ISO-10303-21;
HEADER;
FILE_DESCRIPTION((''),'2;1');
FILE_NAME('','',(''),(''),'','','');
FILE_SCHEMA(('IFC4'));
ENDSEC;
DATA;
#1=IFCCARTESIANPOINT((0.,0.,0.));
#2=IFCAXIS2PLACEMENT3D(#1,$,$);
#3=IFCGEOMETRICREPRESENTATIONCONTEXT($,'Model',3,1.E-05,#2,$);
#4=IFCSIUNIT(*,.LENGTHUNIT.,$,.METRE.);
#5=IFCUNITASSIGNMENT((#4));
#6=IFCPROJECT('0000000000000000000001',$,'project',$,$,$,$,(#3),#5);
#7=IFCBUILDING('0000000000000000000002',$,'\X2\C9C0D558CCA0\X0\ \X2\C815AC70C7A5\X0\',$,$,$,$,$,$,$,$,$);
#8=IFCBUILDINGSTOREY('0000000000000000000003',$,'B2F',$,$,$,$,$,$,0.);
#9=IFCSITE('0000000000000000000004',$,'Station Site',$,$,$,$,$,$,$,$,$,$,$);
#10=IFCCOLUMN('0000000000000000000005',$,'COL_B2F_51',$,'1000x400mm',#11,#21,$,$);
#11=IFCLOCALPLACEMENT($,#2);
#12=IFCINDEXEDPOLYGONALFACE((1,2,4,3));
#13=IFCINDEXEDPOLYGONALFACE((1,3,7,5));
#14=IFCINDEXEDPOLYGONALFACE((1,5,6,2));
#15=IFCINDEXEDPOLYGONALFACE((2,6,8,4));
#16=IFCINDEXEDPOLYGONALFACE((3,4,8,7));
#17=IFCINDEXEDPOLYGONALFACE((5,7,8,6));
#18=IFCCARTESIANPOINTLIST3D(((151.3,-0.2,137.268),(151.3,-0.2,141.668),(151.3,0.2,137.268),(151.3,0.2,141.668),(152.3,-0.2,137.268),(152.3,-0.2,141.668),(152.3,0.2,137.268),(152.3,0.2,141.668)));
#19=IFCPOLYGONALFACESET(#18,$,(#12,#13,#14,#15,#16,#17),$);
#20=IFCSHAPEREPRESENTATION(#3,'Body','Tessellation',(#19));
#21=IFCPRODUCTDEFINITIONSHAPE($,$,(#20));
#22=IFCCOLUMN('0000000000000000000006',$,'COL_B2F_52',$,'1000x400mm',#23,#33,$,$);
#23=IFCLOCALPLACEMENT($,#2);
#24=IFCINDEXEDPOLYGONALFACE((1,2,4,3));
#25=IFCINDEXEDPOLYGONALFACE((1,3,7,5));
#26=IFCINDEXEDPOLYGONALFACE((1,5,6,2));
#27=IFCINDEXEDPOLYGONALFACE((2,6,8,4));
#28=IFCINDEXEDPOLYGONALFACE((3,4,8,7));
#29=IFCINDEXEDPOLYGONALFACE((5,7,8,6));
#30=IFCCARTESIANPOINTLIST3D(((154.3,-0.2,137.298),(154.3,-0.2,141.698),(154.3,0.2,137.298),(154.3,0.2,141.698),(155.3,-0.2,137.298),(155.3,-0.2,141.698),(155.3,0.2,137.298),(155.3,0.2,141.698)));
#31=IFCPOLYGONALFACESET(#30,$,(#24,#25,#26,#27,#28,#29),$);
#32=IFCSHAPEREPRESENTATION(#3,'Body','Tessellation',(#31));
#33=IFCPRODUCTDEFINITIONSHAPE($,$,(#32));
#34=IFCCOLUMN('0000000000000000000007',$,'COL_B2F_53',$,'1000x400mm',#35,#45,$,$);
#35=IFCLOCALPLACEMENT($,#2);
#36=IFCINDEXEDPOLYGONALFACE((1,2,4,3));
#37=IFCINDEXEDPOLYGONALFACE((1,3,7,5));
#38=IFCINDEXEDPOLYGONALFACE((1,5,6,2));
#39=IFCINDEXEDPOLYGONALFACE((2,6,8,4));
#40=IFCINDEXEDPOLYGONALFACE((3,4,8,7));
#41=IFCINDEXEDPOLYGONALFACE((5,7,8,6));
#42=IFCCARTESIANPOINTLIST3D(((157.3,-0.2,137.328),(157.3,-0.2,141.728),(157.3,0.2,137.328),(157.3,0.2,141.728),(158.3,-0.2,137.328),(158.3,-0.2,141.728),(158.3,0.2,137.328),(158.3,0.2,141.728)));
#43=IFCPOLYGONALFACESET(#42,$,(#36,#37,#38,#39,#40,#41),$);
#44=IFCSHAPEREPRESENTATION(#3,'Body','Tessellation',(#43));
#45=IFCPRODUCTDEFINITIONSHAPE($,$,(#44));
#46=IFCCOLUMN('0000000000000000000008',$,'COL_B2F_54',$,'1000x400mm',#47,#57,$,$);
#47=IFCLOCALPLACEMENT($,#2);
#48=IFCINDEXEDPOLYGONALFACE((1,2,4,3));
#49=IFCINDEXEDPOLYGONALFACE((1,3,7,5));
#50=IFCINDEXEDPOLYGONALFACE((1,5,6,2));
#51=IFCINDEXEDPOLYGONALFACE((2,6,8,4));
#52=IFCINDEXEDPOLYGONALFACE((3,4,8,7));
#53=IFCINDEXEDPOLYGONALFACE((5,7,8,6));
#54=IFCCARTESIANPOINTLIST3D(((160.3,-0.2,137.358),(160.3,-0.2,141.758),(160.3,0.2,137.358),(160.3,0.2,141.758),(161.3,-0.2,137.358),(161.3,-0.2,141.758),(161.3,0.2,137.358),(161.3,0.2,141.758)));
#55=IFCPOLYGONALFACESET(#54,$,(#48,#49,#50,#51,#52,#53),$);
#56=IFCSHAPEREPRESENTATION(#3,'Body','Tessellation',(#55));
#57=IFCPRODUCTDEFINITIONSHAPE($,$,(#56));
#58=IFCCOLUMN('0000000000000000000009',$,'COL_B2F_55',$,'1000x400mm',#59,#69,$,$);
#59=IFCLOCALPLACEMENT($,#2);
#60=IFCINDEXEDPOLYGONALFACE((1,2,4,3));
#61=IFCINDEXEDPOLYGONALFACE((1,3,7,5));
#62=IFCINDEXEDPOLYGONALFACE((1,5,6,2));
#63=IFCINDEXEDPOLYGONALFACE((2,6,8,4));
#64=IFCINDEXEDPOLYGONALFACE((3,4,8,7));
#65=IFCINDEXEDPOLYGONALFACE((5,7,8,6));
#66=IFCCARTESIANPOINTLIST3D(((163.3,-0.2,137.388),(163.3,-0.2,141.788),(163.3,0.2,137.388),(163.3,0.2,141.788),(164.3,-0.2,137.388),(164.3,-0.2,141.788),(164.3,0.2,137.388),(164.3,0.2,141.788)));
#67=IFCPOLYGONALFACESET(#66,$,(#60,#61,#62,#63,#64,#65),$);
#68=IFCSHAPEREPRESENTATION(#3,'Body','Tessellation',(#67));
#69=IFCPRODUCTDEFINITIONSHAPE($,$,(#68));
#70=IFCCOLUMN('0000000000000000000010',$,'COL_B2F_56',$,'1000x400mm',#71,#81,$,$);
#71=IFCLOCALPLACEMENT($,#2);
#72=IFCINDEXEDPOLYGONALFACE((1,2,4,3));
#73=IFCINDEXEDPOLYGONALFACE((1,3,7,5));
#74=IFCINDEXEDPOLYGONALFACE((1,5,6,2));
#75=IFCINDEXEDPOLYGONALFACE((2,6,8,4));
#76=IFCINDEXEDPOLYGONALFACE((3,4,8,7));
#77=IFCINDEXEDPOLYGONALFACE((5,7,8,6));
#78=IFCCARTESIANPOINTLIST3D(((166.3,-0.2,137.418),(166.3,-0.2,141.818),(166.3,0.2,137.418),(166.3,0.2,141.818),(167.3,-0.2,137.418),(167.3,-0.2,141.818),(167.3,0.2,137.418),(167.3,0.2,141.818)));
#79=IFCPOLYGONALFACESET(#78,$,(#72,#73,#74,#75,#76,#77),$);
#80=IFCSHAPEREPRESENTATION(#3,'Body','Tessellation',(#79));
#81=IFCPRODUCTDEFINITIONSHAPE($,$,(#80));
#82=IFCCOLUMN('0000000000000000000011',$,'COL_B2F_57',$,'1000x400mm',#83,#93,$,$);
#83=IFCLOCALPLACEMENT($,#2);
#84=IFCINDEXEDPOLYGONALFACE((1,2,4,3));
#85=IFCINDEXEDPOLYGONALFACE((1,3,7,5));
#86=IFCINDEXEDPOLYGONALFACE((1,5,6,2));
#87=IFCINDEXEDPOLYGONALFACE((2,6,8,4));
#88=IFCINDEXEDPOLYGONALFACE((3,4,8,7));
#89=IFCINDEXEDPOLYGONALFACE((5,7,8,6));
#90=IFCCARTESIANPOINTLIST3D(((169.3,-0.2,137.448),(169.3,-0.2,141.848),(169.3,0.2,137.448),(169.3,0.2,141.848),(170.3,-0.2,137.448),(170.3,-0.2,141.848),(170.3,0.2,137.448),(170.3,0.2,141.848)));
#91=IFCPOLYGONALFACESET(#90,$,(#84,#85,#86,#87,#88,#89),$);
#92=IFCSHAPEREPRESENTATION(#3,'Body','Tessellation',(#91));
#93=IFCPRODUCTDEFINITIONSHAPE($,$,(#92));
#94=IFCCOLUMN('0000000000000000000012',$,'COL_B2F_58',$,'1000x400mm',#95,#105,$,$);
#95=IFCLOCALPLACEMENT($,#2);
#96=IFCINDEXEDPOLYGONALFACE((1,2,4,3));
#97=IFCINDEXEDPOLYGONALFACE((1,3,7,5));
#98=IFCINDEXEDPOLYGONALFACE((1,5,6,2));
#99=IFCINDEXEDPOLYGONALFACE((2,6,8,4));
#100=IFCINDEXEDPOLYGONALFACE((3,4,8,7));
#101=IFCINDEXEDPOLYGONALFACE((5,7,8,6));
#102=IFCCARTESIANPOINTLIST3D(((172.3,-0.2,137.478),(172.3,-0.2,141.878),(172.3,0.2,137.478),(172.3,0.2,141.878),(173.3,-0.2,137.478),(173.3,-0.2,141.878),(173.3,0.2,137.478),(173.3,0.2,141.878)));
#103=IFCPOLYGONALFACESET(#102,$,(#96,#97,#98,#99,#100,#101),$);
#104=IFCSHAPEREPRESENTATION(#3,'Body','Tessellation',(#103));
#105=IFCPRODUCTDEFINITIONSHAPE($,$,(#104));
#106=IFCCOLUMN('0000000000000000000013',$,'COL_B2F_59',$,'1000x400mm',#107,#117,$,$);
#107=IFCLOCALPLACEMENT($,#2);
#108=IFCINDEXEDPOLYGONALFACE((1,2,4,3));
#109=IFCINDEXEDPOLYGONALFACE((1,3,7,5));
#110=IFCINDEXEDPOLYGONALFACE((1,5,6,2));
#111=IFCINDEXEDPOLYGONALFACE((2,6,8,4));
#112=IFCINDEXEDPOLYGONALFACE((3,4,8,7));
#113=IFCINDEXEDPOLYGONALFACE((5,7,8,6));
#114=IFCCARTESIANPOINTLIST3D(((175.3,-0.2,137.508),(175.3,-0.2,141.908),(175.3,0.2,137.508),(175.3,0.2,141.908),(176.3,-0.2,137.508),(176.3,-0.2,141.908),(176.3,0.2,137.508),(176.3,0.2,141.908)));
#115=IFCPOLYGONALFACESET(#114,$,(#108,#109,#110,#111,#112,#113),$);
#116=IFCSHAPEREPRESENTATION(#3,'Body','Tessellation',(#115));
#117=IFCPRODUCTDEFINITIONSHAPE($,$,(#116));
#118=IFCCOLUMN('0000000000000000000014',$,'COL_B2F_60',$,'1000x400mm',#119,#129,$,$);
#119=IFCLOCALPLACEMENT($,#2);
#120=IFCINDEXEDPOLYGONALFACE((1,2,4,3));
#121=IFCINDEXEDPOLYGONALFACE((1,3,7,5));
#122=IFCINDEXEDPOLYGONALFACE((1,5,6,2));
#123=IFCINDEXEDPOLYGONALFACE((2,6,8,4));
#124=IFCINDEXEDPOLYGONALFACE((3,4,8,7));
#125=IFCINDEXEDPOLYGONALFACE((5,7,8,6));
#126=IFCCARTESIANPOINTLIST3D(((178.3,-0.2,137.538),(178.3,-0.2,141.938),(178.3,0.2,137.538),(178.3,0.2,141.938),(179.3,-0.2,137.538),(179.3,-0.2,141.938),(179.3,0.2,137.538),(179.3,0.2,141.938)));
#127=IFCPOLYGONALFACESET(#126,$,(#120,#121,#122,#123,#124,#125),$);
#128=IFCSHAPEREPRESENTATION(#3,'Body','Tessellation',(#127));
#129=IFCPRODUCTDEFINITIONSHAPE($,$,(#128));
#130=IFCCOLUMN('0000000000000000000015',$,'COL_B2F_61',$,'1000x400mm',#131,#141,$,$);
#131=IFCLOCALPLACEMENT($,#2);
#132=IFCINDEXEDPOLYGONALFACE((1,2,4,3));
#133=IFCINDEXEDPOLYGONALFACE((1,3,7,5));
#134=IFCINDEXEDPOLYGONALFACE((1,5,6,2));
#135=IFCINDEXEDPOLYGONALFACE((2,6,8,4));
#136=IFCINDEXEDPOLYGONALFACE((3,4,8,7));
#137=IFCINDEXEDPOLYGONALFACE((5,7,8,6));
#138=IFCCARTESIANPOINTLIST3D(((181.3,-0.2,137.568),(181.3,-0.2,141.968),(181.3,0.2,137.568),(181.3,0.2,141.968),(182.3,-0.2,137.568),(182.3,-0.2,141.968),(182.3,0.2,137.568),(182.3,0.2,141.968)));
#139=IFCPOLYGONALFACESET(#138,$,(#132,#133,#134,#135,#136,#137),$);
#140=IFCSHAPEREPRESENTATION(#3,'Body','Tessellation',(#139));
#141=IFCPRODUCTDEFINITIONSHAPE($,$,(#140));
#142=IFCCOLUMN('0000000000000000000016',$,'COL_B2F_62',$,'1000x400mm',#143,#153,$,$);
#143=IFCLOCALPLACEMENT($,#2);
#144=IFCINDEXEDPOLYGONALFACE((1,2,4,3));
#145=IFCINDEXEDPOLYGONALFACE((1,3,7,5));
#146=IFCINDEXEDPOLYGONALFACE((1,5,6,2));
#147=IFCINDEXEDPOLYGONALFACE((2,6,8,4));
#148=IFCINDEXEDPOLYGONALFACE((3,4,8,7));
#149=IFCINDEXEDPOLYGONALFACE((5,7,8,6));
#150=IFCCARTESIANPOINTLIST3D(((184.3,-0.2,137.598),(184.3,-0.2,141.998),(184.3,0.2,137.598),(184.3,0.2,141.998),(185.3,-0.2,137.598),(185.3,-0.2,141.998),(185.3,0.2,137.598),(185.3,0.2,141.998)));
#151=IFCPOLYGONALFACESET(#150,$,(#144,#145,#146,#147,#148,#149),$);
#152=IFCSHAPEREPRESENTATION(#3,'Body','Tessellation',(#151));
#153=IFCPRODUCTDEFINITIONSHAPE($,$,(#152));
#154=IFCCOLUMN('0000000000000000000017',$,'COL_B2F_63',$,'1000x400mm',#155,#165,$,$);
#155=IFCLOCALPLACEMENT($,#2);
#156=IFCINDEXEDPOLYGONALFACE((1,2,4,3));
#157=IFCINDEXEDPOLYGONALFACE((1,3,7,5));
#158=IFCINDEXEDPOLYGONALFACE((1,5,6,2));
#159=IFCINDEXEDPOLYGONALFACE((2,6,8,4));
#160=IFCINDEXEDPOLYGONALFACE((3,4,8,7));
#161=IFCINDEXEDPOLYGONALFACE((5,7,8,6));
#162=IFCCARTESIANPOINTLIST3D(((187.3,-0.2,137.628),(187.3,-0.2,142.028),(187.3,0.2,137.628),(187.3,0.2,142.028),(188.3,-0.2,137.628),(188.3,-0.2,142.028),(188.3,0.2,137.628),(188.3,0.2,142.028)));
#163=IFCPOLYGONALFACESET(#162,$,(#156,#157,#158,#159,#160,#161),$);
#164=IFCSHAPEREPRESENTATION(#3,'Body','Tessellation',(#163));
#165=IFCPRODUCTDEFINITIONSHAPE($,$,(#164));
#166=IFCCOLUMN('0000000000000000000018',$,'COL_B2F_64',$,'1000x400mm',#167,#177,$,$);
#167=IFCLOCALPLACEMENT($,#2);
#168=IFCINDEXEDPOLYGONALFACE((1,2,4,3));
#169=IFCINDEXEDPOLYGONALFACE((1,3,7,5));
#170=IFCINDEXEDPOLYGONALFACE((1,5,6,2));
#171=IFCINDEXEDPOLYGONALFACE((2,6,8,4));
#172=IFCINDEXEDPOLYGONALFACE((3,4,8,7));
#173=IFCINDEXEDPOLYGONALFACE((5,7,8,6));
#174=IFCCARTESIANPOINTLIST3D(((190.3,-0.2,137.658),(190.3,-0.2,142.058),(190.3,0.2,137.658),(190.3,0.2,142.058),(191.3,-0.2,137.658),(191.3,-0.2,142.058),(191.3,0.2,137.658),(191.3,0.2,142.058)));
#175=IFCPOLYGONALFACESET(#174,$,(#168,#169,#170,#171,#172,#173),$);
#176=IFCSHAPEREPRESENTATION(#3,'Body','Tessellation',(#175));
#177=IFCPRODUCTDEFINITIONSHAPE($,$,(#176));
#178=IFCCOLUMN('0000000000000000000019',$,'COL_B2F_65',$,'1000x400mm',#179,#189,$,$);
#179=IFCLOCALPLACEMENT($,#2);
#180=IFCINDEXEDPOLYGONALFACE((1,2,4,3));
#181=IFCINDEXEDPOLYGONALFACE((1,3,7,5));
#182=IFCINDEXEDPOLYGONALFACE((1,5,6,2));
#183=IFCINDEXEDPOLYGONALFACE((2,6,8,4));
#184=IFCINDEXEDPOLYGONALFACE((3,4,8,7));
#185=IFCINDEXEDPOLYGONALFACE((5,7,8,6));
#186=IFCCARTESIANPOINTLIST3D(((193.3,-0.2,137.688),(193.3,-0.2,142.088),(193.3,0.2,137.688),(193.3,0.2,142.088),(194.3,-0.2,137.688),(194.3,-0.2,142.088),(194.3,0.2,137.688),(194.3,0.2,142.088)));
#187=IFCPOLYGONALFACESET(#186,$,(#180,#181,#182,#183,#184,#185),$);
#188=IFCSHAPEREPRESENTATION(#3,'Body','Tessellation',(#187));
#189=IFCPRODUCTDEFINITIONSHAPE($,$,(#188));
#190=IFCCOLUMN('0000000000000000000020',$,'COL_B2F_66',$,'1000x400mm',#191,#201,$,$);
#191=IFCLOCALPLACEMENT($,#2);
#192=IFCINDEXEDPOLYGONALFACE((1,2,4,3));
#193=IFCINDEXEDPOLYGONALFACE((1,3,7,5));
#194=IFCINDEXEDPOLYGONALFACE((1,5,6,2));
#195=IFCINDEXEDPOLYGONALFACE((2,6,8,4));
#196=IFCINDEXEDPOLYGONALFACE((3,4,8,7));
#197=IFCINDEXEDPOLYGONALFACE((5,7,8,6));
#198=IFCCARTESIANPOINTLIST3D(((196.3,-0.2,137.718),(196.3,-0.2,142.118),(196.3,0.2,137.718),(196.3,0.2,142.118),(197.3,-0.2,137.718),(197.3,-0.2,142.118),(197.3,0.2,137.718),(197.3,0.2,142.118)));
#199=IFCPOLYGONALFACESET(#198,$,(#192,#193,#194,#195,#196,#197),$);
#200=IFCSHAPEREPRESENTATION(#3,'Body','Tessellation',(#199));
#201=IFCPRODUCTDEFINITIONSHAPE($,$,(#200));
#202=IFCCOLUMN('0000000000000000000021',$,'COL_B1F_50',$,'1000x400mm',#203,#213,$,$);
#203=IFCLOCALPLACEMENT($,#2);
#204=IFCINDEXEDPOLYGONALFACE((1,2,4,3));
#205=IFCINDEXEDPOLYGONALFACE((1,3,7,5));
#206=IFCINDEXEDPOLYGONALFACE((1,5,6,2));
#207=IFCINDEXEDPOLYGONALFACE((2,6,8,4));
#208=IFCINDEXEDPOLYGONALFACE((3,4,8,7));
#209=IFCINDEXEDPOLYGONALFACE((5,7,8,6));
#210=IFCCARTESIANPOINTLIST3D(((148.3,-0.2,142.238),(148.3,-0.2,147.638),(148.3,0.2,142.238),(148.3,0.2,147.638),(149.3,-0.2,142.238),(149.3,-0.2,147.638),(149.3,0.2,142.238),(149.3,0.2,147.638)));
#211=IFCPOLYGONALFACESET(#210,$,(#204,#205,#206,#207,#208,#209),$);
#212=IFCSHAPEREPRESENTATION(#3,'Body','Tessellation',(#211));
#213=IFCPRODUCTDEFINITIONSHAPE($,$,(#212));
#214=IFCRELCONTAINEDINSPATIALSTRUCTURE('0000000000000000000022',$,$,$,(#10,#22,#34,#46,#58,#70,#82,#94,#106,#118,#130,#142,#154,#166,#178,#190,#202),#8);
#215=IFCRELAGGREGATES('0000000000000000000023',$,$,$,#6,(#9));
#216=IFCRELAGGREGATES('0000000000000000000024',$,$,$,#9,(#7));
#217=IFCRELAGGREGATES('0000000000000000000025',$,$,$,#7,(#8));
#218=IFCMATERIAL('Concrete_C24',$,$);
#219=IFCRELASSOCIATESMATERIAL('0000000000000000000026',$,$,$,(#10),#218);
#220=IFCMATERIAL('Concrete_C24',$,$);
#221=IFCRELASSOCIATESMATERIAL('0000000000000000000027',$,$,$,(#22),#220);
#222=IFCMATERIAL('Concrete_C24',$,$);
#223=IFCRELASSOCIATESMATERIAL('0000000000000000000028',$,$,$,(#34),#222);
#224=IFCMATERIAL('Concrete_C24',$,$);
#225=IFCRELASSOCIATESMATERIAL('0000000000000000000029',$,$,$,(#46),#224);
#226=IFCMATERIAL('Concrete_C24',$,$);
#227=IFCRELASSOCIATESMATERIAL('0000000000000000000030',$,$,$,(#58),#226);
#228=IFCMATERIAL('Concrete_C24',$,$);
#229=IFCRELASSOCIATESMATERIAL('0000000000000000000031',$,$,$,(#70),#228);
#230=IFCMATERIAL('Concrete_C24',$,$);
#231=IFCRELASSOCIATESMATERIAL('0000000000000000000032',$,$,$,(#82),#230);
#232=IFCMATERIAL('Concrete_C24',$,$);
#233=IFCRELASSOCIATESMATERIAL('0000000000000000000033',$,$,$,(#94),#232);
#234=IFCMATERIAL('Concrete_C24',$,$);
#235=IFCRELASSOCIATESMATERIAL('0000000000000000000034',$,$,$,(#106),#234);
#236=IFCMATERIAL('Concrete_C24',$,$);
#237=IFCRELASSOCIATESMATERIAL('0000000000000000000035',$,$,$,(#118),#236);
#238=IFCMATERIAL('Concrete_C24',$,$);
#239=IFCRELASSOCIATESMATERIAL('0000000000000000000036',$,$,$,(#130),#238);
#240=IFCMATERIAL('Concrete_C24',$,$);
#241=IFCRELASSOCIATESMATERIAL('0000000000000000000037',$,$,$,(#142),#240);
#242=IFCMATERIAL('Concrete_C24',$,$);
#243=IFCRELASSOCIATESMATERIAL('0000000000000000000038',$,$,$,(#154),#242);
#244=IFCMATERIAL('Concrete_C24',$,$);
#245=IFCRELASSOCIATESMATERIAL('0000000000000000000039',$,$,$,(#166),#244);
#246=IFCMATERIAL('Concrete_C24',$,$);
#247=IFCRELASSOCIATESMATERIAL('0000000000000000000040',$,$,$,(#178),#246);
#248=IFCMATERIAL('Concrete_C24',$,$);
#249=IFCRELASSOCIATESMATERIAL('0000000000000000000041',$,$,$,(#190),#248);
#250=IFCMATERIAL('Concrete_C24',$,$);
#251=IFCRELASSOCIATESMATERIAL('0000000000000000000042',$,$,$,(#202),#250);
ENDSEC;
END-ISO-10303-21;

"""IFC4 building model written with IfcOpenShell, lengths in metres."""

from ifc_helpers import new_model, si_unit, frame, origin, place, context, project, spatial, rectangle, extrude, material, element, save


model = new_model("IFC4")

# Units and contexts
model_context = context("Model", 3, precision=1e-05, world=origin())
ifc_project = project(units=[si_unit("LENGTHUNIT", "METRE")], contexts=[model_context])

# Site, building, storey
site = spatial("IfcSite", under=ifc_project, Name="Station Site")
building = spatial("IfcBuilding", under=site, Name="지하철 정거장")
storey = spatial("IfcBuildingStorey", under=building, Name="B2F", Elevation=0.0)

# Columns
ifc_material_1 = material(Name="Concrete_C24")
column_1_placement = place(None, frame((151.8, 0.0, 137.268)))
element("IfcColumn", 1, at=column_1_placement, inside=storey, material=ifc_material_1, Name="COL_B2F_51", ObjectType="1000x400mm", context=model_context, shape_type="SweptSolid", body=[
    extrude(rectangle(XDim=1.0, YDim=0.4), origin(), (0.0, 0.0, 1.0), 4.4),
])
ifc_material_2 = material(Name="Concrete_C24")
column_2_placement = place(None, frame((154.8, 0.0, 137.298)))
element("IfcColumn", 2, at=column_2_placement, inside=storey, material=ifc_material_2, Name="COL_B2F_52", ObjectType="1000x400mm", context=model_context, shape_type="SweptSolid", body=[
    extrude(rectangle(XDim=1.0, YDim=0.4), origin(), (0.0, 0.0, 1.0), 4.4),
])
ifc_material_3 = material(Name="Concrete_C24")
column_3_placement = place(None, frame((157.8, 0.0, 137.328)))
element("IfcColumn", 3, at=column_3_placement, inside=storey, material=ifc_material_3, Name="COL_B2F_53", ObjectType="1000x400mm", context=model_context, shape_type="SweptSolid", body=[
    extrude(rectangle(XDim=1.0, YDim=0.4), origin(), (0.0, 0.0, 1.0), 4.4),
])
ifc_material_4 = material(Name="Concrete_C24")
column_4_placement = place(None, frame((160.8, 0.0, 137.358)))
element("IfcColumn", 4, at=column_4_placement, inside=storey, material=ifc_material_4, Name="COL_B2F_54", ObjectType="1000x400mm", context=model_context, shape_type="SweptSolid", body=[
    extrude(rectangle(XDim=1.0, YDim=0.4), origin(), (0.0, 0.0, 1.0), 4.4),
])
ifc_material_5 = material(Name="Concrete_C24")
column_5_placement = place(None, frame((163.8, 0.0, 137.388)))
element("IfcColumn", 5, at=column_5_placement, inside=storey, material=ifc_material_5, Name="COL_B2F_55", ObjectType="1000x400mm", context=model_context, shape_type="SweptSolid", body=[
    extrude(rectangle(XDim=1.0, YDim=0.4), origin(), (0.0, 0.0, 1.0), 4.4),
])
ifc_material_6 = material(Name="Concrete_C24")
column_6_placement = place(None, frame((166.8, 0.0, 137.418)))
element("IfcColumn", 6, at=column_6_placement, inside=storey, material=ifc_material_6, Name="COL_B2F_56", ObjectType="1000x400mm", context=model_context, shape_type="SweptSolid", body=[
    extrude(rectangle(XDim=1.0, YDim=0.4), origin(), (0.0, 0.0, 1.0), 4.4),
])
ifc_material_7 = material(Name="Concrete_C24")
column_7_placement = place(None, frame((169.8, 0.0, 137.448)))
element("IfcColumn", 7, at=column_7_placement, inside=storey, material=ifc_material_7, Name="COL_B2F_57", ObjectType="1000x400mm", context=model_context, shape_type="SweptSolid", body=[
    extrude(rectangle(XDim=1.0, YDim=0.4), origin(), (0.0, 0.0, 1.0), 4.4),
])
ifc_material_8 = material(Name="Concrete_C24")
column_8_placement = place(None, frame((172.8, 0.0, 137.478)))
element("IfcColumn", 8, at=column_8_placement, inside=storey, material=ifc_material_8, Name="COL_B2F_58", ObjectType="1000x400mm", context=model_context, shape_type="SweptSolid", body=[
    extrude(rectangle(XDim=1.0, YDim=0.4), origin(), (0.0, 0.0, 1.0), 4.4),
])
ifc_material_9 = material(Name="Concrete_C24")
column_9_placement = place(None, frame((175.8, 0.0, 137.508)))
element("IfcColumn", 9, at=column_9_placement, inside=storey, material=ifc_material_9, Name="COL_B2F_59", ObjectType="1000x400mm", context=model_context, shape_type="SweptSolid", body=[
    extrude(rectangle(XDim=1.0, YDim=0.4), origin(), (0.0, 0.0, 1.0), 4.4),
])
ifc_material_10 = material(Name="Concrete_C24")
column_10_placement = place(None, frame((178.8, 0.0, 137.538)))
element("IfcColumn", 10, at=column_10_placement, inside=storey, material=ifc_material_10, Name="COL_B2F_60", ObjectType="1000x400mm", context=model_context, shape_type="SweptSolid", body=[
    extrude(rectangle(XDim=1.0, YDim=0.4), origin(), (0.0, 0.0, 1.0), 4.4),
])
ifc_material_11 = material(Name="Concrete_C24")
column_11_placement = place(None, frame((181.8, 0.0, 137.568)))
element("IfcColumn", 11, at=column_11_placement, inside=storey, material=ifc_material_11, Name="COL_B2F_61", ObjectType="1000x400mm", context=model_context, shape_type="SweptSolid", body=[
    extrude(rectangle(XDim=1.0, YDim=0.4), origin(), (0.0, 0.0, 1.0), 4.4),
])
ifc_material_12 = material(Name="Concrete_C24")
column_12_placement = place(None, frame((184.8, 0.0, 137.598)))
element("IfcColumn", 12, at=column_12_placement, inside=storey, material=ifc_material_12, Name="COL_B2F_62", ObjectType="1000x400mm", context=model_context, shape_type="SweptSolid", body=[
    extrude(rectangle(XDim=1.0, YDim=0.4), origin(), (0.0, 0.0, 1.0), 4.4),
])
ifc_material_13 = material(Name="Concrete_C24")
column_13_placement = place(None, frame((187.8, 0.0, 137.628)))
element("IfcColumn", 13, at=column_13_placement, inside=storey, material=ifc_material_13, Name="COL_B2F_63", ObjectType="1000x400mm", context=model_context, shape_type="SweptSolid", body=[
    extrude(rectangle(XDim=1.0, YDim=0.4), origin(), (0.0, 0.0, 1.0), 4.4),
])
ifc_material_14 = material(Name="Concrete_C24")
column_14_placement = place(None, frame((190.8, 0.0, 137.658)))
element("IfcColumn", 14, at=column_14_placement, inside=storey, material=ifc_material_14, Name="COL_B2F_64", ObjectType="1000x400mm", context=model_context, shape_type="SweptSolid", body=[
    extrude(rectangle(XDim=1.0, YDim=0.4), origin(), (0.0, 0.0, 1.0), 4.4),
])
ifc_material_15 = material(Name="Concrete_C24")
column_15_placement = place(None, frame((193.8, 0.0, 137.688)))
element("IfcColumn", 15, at=column_15_placement, inside=storey, material=ifc_material_15, Name="COL_B2F_65", ObjectType="1000x400mm", context=model_context, shape_type="SweptSolid", body=[
    extrude(rectangle(XDim=1.0, YDim=0.4), origin(), (0.0, 0.0, 1.0), 4.4),
])
ifc_material_16 = material(Name="Concrete_C24")
column_16_placement = place(None, frame((196.8, 0.0, 137.718)))
element("IfcColumn", 16, at=column_16_placement, inside=storey, material=ifc_material_16, Name="COL_B2F_66", ObjectType="1000x400mm", context=model_context, shape_type="SweptSolid", body=[
    extrude(rectangle(XDim=1.0, YDim=0.4), origin(), (0.0, 0.0, 1.0), 4.4),
])
ifc_material_17 = material(Name="Concrete_C24")
column_17_placement = place(None, frame((148.8, 0.0, 142.238)))
element("IfcColumn", 17, at=column_17_placement, inside=storey, material=ifc_material_17, Name="COL_B1F_50", ObjectType="1000x400mm", context=model_context, shape_type="SweptSolid", body=[
    extrude(rectangle(XDim=1.0, YDim=0.4), origin(), (0.0, 0.0, 1.0), 5.4),
])

save(model, "model.ifc")
